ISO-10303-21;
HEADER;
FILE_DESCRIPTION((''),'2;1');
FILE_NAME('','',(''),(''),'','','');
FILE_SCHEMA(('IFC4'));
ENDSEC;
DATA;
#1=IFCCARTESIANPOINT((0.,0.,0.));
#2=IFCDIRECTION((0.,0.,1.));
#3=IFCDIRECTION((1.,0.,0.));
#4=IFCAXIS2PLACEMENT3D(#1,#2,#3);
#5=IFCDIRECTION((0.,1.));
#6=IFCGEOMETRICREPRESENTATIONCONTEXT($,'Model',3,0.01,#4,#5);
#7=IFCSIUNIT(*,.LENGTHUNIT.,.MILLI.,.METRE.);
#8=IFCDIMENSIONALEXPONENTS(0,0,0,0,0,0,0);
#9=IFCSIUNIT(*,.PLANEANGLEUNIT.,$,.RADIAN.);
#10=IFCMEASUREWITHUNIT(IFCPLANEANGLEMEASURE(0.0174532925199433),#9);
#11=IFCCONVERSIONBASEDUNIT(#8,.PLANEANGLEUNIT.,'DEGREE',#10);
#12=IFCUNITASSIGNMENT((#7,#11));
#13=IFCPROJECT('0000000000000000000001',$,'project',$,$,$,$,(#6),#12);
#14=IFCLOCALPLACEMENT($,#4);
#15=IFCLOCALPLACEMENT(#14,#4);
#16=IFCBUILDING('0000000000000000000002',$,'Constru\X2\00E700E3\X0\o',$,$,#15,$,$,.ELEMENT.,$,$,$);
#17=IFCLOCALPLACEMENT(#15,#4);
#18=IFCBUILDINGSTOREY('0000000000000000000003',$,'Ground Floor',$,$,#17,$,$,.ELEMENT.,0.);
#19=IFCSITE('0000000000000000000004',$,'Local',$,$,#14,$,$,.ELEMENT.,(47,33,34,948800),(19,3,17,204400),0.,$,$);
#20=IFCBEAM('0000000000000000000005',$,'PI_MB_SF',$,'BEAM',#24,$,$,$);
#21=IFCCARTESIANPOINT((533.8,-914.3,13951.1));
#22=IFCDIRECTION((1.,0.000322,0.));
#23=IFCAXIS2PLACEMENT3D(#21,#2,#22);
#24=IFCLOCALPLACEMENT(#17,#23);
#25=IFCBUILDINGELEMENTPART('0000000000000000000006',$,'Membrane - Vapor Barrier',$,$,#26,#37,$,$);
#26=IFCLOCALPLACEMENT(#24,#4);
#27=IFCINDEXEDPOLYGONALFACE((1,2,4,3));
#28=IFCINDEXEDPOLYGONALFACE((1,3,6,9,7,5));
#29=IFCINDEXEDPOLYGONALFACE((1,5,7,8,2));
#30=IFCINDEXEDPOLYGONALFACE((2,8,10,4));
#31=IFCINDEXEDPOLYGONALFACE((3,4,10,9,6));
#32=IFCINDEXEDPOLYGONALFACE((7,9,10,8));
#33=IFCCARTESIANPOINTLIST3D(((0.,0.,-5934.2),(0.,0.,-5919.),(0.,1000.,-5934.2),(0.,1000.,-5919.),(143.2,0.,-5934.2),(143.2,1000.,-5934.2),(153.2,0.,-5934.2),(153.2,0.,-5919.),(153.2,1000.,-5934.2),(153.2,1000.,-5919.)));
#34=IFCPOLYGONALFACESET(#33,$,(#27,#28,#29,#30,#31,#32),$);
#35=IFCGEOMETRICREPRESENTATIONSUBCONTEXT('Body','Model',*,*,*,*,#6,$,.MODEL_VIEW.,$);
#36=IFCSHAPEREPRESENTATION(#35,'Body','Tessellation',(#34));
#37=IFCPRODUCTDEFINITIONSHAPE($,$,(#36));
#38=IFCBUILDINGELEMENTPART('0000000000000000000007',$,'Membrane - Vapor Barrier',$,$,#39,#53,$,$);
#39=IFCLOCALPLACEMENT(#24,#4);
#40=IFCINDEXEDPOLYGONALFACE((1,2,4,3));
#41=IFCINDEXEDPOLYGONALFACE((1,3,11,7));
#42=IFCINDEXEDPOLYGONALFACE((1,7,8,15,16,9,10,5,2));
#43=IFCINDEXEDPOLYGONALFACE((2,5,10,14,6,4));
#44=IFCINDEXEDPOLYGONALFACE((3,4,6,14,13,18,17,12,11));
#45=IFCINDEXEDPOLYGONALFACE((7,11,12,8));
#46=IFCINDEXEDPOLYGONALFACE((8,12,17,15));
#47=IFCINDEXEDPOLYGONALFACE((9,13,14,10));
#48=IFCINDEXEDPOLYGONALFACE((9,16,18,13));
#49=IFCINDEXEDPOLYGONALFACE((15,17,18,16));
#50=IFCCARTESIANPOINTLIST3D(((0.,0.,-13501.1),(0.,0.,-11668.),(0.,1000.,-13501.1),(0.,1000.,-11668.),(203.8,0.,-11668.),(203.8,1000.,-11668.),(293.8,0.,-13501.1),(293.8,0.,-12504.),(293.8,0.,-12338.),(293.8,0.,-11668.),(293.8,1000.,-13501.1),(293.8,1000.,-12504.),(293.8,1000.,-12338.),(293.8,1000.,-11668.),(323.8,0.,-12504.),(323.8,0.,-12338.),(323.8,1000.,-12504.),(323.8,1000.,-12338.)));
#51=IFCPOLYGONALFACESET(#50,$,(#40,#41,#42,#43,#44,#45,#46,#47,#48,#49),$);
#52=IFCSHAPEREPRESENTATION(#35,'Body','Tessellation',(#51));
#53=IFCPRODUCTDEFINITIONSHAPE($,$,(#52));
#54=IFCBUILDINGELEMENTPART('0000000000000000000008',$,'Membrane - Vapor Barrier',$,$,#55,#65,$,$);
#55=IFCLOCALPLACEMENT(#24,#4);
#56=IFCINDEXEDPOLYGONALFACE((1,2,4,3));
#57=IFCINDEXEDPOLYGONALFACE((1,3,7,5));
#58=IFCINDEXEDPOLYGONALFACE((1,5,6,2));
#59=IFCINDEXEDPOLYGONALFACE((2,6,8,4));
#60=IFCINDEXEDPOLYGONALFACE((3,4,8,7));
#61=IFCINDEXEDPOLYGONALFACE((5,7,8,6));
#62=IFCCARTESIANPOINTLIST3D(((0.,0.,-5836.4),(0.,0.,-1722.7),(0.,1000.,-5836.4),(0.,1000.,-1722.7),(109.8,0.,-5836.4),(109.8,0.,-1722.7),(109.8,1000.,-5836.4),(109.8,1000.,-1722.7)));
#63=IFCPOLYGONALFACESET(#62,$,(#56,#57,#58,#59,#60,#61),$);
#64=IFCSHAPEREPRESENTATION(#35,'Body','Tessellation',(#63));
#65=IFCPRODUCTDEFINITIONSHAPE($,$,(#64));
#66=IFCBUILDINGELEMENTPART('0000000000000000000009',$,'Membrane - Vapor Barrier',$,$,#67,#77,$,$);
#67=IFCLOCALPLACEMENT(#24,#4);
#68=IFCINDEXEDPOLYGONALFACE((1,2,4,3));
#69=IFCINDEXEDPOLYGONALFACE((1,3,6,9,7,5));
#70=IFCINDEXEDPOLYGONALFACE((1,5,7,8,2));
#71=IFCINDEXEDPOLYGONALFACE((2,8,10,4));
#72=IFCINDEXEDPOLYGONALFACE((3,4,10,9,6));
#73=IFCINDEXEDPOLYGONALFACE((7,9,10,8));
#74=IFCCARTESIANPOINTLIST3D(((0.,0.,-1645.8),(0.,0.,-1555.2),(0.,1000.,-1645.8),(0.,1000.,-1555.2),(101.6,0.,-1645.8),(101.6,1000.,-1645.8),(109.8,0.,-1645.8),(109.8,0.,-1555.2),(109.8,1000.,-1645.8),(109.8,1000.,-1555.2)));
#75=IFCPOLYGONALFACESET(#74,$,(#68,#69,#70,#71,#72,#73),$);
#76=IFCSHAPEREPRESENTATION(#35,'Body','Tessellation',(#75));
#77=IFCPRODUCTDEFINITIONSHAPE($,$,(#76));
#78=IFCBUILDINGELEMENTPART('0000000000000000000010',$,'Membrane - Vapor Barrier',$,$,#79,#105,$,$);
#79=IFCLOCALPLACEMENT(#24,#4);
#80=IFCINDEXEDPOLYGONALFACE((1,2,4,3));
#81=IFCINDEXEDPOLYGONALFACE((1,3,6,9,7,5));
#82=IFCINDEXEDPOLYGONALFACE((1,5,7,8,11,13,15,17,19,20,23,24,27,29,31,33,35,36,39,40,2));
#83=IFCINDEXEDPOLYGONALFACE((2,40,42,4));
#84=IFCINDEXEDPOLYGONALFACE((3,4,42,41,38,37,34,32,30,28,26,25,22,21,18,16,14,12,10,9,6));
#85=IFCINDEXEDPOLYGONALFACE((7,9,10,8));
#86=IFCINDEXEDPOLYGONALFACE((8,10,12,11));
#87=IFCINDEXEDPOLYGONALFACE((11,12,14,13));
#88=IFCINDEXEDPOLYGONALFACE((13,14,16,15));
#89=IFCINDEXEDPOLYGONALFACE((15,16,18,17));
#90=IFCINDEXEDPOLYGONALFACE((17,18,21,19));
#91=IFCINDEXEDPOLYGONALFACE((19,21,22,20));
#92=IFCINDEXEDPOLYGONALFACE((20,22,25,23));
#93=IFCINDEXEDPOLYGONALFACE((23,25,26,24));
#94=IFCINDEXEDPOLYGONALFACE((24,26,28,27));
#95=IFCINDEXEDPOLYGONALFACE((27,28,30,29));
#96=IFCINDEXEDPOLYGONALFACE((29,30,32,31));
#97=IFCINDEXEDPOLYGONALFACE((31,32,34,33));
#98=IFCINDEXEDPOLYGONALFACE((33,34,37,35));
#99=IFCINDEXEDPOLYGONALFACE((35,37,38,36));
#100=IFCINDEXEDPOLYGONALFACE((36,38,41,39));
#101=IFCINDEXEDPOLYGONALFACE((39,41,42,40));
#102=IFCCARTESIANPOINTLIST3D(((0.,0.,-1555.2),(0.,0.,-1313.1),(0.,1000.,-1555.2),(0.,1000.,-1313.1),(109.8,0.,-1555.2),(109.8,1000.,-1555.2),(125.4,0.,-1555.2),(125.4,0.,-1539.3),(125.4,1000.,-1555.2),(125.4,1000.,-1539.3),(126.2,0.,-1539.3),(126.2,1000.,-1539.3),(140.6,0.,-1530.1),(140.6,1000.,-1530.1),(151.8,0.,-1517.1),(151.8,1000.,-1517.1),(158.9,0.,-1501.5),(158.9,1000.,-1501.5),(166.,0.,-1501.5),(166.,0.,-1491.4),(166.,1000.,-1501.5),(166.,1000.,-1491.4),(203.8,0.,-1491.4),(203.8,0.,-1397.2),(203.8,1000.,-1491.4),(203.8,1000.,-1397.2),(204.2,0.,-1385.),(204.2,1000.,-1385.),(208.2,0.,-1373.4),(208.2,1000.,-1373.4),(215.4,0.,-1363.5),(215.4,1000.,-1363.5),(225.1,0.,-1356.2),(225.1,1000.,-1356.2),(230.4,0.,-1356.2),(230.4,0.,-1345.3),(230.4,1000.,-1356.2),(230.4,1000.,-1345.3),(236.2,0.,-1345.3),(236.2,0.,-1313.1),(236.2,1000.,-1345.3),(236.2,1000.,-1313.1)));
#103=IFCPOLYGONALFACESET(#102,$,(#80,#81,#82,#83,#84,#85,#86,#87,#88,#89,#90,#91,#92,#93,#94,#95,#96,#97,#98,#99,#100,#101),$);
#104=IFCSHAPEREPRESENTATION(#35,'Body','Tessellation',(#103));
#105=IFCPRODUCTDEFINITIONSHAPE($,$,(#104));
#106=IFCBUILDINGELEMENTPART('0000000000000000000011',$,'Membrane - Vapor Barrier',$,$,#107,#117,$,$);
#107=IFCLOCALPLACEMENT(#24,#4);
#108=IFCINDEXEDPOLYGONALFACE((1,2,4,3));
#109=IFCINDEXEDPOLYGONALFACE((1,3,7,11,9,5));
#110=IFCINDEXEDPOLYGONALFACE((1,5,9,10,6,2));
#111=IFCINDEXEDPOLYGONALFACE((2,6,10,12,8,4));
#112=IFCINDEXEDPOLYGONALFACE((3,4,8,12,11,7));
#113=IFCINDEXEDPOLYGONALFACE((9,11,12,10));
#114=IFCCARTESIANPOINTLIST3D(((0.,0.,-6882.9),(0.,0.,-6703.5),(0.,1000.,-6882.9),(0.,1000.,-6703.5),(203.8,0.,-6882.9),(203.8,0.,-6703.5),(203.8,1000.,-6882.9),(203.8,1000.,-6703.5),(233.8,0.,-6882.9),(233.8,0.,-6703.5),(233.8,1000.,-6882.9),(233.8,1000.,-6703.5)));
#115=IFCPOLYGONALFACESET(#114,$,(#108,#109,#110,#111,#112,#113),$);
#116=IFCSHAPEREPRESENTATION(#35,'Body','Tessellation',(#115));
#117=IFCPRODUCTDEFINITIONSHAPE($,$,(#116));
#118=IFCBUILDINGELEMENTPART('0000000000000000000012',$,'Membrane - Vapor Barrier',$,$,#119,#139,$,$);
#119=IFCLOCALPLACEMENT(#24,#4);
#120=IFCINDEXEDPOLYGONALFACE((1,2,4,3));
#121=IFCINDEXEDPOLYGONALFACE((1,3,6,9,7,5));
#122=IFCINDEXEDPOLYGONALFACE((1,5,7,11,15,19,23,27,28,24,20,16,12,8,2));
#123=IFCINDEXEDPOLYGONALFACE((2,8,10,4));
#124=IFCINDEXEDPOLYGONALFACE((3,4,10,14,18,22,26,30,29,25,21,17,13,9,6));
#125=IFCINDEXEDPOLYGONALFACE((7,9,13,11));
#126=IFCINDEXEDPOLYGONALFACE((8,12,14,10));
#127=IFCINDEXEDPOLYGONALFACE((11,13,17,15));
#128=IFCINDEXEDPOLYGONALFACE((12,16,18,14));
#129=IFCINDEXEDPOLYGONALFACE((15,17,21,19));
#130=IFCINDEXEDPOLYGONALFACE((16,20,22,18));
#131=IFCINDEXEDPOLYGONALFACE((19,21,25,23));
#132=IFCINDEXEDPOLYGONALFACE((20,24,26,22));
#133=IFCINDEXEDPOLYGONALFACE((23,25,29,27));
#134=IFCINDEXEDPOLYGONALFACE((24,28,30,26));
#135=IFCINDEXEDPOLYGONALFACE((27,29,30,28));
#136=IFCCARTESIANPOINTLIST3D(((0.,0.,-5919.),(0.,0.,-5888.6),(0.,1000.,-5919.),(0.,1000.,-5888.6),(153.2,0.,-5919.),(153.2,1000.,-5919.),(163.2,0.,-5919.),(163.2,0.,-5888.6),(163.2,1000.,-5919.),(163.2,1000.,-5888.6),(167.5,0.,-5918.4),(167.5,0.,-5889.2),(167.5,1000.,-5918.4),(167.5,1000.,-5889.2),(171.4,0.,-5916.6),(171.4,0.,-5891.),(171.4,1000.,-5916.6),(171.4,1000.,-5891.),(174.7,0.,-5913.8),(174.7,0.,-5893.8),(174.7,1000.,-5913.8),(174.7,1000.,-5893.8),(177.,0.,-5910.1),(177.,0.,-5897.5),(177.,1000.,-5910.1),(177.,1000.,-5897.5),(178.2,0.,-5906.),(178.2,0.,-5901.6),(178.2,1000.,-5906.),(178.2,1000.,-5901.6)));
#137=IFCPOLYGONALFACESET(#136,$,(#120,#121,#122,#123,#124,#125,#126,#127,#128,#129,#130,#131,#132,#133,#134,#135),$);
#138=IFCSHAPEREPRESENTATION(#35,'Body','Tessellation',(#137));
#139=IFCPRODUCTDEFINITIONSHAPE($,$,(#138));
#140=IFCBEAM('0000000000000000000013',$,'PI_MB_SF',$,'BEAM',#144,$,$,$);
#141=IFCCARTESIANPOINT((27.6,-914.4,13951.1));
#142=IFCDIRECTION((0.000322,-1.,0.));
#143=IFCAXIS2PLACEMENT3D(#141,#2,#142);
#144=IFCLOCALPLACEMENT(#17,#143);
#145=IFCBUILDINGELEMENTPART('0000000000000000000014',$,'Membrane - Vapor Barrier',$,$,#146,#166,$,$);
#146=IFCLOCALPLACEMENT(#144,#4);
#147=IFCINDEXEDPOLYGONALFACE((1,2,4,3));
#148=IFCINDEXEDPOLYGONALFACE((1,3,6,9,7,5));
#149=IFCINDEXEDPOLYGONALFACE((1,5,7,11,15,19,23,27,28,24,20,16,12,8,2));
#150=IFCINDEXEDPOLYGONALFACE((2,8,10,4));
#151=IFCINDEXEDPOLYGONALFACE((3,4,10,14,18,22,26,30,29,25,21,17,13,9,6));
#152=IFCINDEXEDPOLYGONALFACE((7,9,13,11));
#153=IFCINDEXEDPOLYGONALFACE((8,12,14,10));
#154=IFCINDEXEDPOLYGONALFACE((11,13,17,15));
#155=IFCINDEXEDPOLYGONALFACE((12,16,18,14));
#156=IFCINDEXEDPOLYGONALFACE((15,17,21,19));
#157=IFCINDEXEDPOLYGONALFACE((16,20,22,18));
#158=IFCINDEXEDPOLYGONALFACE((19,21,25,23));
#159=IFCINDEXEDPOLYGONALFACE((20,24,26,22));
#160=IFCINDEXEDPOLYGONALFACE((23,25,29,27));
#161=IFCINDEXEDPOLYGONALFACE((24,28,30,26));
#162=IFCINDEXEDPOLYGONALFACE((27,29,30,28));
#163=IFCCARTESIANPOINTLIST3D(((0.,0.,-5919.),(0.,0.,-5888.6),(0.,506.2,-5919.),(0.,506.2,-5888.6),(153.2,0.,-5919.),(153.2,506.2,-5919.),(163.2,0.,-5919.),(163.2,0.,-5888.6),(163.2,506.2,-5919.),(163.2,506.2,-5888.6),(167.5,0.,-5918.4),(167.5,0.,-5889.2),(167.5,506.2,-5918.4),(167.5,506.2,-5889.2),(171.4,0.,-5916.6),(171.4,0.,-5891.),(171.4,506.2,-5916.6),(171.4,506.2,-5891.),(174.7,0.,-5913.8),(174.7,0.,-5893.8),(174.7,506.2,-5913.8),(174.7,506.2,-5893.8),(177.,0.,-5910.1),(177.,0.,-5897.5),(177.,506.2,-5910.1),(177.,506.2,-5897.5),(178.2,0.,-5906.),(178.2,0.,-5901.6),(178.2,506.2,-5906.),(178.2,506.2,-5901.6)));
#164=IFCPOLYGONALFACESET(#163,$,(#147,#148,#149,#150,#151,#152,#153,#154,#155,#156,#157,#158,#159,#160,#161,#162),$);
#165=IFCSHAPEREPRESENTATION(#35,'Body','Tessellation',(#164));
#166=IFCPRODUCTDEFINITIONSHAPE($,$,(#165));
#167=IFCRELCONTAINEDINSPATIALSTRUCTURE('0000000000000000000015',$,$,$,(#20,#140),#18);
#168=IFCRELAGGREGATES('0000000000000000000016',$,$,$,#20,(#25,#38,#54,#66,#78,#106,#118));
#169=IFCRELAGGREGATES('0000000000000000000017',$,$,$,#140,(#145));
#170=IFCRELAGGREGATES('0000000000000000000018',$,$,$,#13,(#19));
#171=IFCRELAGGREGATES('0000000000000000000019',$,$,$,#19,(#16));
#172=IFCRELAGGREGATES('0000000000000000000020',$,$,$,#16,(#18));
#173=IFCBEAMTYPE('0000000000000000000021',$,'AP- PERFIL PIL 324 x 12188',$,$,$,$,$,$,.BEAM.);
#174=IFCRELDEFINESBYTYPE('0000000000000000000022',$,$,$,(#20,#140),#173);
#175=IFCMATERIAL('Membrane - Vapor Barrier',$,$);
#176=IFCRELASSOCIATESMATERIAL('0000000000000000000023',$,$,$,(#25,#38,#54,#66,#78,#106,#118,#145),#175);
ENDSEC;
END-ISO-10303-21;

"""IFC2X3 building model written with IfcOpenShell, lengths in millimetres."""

from ifc_helpers import new_model, entity, si_unit, converted_unit, point, direction, frame, frame_2d, origin_with_axes, place, context, subcontext, project, spatial, polyline, circle_curve, parameter, trimmed, segment, composite_curve, outline, extrude, material, type_object, element, aggregate, save


model = new_model("IFC2X3")

# Units and contexts
model_context = context("Model", 3, precision=0.01, world=origin_with_axes(), true_north=direction((0.0, 1.0)))
body_context = subcontext(model_context, "Body", "Model", "MODEL_VIEW")
ifc_project = project(units=[si_unit("LENGTHUNIT", "METRE", prefix="MILLI"), converted_unit("PLANEANGLEUNIT", "DEGREE", entity("IfcPlaneAngleMeasure", 0.0174532925199433), si_unit("PLANEANGLEUNIT", "RADIAN"), dimensions=[0, 0, 0, 0, 0, 0, 0])], contexts=[model_context])

# Site, building, storey
site_placement = place(None, origin_with_axes())
site = spatial("IfcSite", under=ifc_project, at=site_placement, Name="Local", CompositionType="ELEMENT", RefLatitude=(47, 33, 34, 948800), RefLongitude=(19, 3, 17, 204400), RefElevation=0.0)
building_placement = place(site_placement, origin_with_axes())
building = spatial("IfcBuilding", under=site, at=building_placement, Name="Construção", CompositionType="ELEMENT")
storey_placement = place(building_placement, origin_with_axes())
storey = spatial("IfcBuildingStorey", under=building, at=storey_placement, Name="Ground Floor", CompositionType="ELEMENT", Elevation=0.0)

# Shared definitions
ifc_material_1 = material(Name="Membrane - Vapor Barrier")

# Beams, building element parts
beam_type_1 = type_object("IfcBeamType", Name="AP- PERFIL PIL 324 x 12188", PredefinedType="BEAM")
beam_1_placement = place(storey_placement, frame((533.8, -914.3, 13951.1), z_axis=(0.0, 0.0, 1.0), x_axis=(1.0, 0.000322, 0.0)))
beam_1 = element("IfcBeam", 1, at=beam_1_placement, inside=storey, type_object=beam_type_1, Name="PI_MB_SF", ObjectType="BEAM")
building_element_part_1_placement = place(beam_1_placement, origin_with_axes())
building_element_part_1 = element("IfcBuildingElementPart", 2, at=building_element_part_1_placement, material=ifc_material_1, Name="Membrane - Vapor Barrier", context=body_context, shape_type="SweptSolid", body=[
    extrude(outline(polyline([(0.0, -5934.2), (143.2, -5934.2), (153.2, -5934.2), (153.2, -5919.0), (0.0, -5919.0), (0.0, -5934.2)])), frame((0.0, 1000.0, 0.0), z_axis=(0.0, -1.0, 0.0), x_axis=(1.0, 0.0, 0.0)), (0.0, 0.0, 1.0), 1000.0),
])
building_element_part_2_placement = place(beam_1_placement, origin_with_axes())
building_element_part_2 = element("IfcBuildingElementPart", 3, at=building_element_part_2_placement, material=ifc_material_1, Name="Membrane - Vapor Barrier", context=body_context, shape_type="SweptSolid", body=[
    extrude(outline(polyline([(0.0, -13501.1), (293.8, -13501.1), (293.8, -12504.0), (323.8, -12504.0), (323.8, -12338.0), (293.8, -12338.0), (293.8, -11668.0), (203.8, -11668.0), (0.0, -11668.0), (0.0, -13501.1)])), frame((0.0, 1000.0, 0.0), z_axis=(0.0, -1.0, 0.0), x_axis=(1.0, 0.0, 0.0)), (0.0, 0.0, 1.0), 1000.0),
])
building_element_part_3_placement = place(beam_1_placement, origin_with_axes())
building_element_part_3 = element("IfcBuildingElementPart", 4, at=building_element_part_3_placement, material=ifc_material_1, Name="Membrane - Vapor Barrier", context=body_context, shape_type="SweptSolid", body=[
    extrude(outline(polyline([(109.8, -1722.7), (0.0, -1722.7), (0.0, -5836.4), (109.8, -5836.4), (109.8, -1722.7)])), frame((0.0, 1000.0, 0.0), z_axis=(0.0, -1.0, 0.0), x_axis=(1.0, 0.0, 0.0)), (0.0, 0.0, 1.0), 1000.0),
])
building_element_part_4_placement = place(beam_1_placement, origin_with_axes())
building_element_part_4 = element("IfcBuildingElementPart", 5, at=building_element_part_4_placement, material=ifc_material_1, Name="Membrane - Vapor Barrier", context=body_context, shape_type="SweptSolid", body=[
    extrude(outline(polyline([(0.0, -1645.8), (101.6, -1645.8), (109.8, -1645.8), (109.8, -1555.2), (0.0, -1555.2), (0.0, -1645.8)])), frame((0.0, 1000.0, 0.0), z_axis=(0.0, -1.0, 0.0), x_axis=(1.0, 0.0, 0.0)), (0.0, 0.0, 1.0), 1000.0),
])
building_element_part_5_placement = place(beam_1_placement, origin_with_axes())
building_element_part_5 = element("IfcBuildingElementPart", 6, at=building_element_part_5_placement, material=ifc_material_1, Name="Membrane - Vapor Barrier", context=body_context, shape_type="SweptSolid", body=[
    extrude(outline(composite_curve([segment(polyline([(0.0, -1555.2), (109.8, -1555.2), (125.4, -1555.2), (125.4, -1539.3), (126.2, -1539.3)]), True, "CONTINUOUS"), segment(trimmed(circle_curve(frame_2d((101.8, -1485.2), x_axis=(0.411627, -0.911352)), 59.4), [point((126.2, -1539.3)), parameter(0.0)], [point((158.9, -1501.5)), parameter(49.79606)], True, "CARTESIAN"), True, "CONTINUOUS"), segment(polyline([(158.9, -1501.5), (166.0, -1501.5), (166.0, -1491.4), (203.8, -1491.4), (203.8, -1397.2)]), True, "CONTINUOUS"), segment(trimmed(circle_curve(frame_2d((245.0, -1392.6), x_axis=(-0.480333, 0.877086)), 41.5), [point((203.8, -1397.2)), parameter(67.594129)], [point((225.1, -1356.2)), parameter(0.0)], False, "CARTESIAN"), True, "CONTINUOUS"), segment(polyline([(225.1, -1356.2), (230.4, -1356.2), (230.4, -1345.3), (236.2, -1345.3), (236.2, -1313.1), (0.0, -1313.1), (0.0, -1555.2)]), True, "CONTINUOUS")], self_intersect=False)), frame((0.0, 1000.0, 0.0), z_axis=(0.0, -1.0, 0.0), x_axis=(1.0, 0.0, 0.0)), (0.0, 0.0, 1.0), 1000.0),
])
building_element_part_6_placement = place(beam_1_placement, origin_with_axes())
building_element_part_6 = element("IfcBuildingElementPart", 7, at=building_element_part_6_placement, material=ifc_material_1, Name="Membrane - Vapor Barrier", context=body_context, shape_type="SweptSolid", body=[
    extrude(outline(polyline([(233.8, -6882.9), (233.8, -6703.5), (203.8, -6703.5), (0.0, -6703.5), (0.0, -6882.9), (203.8, -6882.9), (233.8, -6882.9)])), frame((0.0, 1000.0, 0.0), z_axis=(0.0, -1.0, 0.0), x_axis=(1.0, 0.0, 0.0)), (0.0, 0.0, 1.0), 1000.0),
])
building_element_part_7_placement = place(beam_1_placement, origin_with_axes())
building_element_part_7 = element("IfcBuildingElementPart", 8, at=building_element_part_7_placement, material=ifc_material_1, Name="Membrane - Vapor Barrier", context=body_context, shape_type="SweptSolid", body=[
    extrude(outline(composite_curve([segment(polyline([(0.0, -5888.6), (0.0, -5919.0), (153.2, -5919.0), (163.2, -5919.0)]), True, "CONTINUOUS"), segment(trimmed(circle_curve(frame_2d((163.2, -5903.8), x_axis=(0.0, -1.0)), 15.2), [point((163.2, -5919.0)), parameter(0.0)], [point((163.2, -5888.6)), parameter(180.0)], True, "CARTESIAN"), True, "CONTINUOUS"), segment(polyline([(163.2, -5888.6), (0.0, -5888.6)]), True, "CONTINUOUS")], self_intersect=False)), frame((0.0, 1000.0, 0.0), z_axis=(0.0, -1.0, 0.0), x_axis=(1.0, 0.0, 0.0)), (0.0, 0.0, 1.0), 1000.0),
])
aggregate(beam_1, [building_element_part_1, building_element_part_2, building_element_part_3, building_element_part_4, building_element_part_5, building_element_part_6, building_element_part_7])
beam_2_placement = place(storey_placement, frame((27.6, -914.4, 13951.1), z_axis=(0.0, 0.0, 1.0), x_axis=(0.000322, -1.0, 0.0)))
beam_2 = element("IfcBeam", 9, at=beam_2_placement, inside=storey, type_object=beam_type_1, Name="PI_MB_SF", ObjectType="BEAM")
building_element_part_8_placement = place(beam_2_placement, origin_with_axes())
building_element_part_8 = element("IfcBuildingElementPart", 10, at=building_element_part_8_placement, material=ifc_material_1, Name="Membrane - Vapor Barrier", context=body_context, shape_type="SweptSolid", body=[
    extrude(outline(composite_curve([segment(polyline([(0.0, -5888.6), (0.0, -5919.0), (153.2, -5919.0), (163.2, -5919.0)]), True, "CONTINUOUS"), segment(trimmed(circle_curve(frame_2d((163.2, -5903.8), x_axis=(0.0, -1.0)), 15.2), [point((163.2, -5919.0)), parameter(0.0)], [point((163.2, -5888.6)), parameter(180.0)], True, "CARTESIAN"), True, "CONTINUOUS"), segment(polyline([(163.2, -5888.6), (0.0, -5888.6)]), True, "CONTINUOUS")], self_intersect=False)), frame((0.0, 506.2, 0.0), z_axis=(0.0, -1.0, 0.0), x_axis=(1.0, 0.0, 0.0)), (0.0, 0.0, 1.0), 506.2),
])
aggregate(beam_2, [building_element_part_8])

save(model, "model.ifc")
